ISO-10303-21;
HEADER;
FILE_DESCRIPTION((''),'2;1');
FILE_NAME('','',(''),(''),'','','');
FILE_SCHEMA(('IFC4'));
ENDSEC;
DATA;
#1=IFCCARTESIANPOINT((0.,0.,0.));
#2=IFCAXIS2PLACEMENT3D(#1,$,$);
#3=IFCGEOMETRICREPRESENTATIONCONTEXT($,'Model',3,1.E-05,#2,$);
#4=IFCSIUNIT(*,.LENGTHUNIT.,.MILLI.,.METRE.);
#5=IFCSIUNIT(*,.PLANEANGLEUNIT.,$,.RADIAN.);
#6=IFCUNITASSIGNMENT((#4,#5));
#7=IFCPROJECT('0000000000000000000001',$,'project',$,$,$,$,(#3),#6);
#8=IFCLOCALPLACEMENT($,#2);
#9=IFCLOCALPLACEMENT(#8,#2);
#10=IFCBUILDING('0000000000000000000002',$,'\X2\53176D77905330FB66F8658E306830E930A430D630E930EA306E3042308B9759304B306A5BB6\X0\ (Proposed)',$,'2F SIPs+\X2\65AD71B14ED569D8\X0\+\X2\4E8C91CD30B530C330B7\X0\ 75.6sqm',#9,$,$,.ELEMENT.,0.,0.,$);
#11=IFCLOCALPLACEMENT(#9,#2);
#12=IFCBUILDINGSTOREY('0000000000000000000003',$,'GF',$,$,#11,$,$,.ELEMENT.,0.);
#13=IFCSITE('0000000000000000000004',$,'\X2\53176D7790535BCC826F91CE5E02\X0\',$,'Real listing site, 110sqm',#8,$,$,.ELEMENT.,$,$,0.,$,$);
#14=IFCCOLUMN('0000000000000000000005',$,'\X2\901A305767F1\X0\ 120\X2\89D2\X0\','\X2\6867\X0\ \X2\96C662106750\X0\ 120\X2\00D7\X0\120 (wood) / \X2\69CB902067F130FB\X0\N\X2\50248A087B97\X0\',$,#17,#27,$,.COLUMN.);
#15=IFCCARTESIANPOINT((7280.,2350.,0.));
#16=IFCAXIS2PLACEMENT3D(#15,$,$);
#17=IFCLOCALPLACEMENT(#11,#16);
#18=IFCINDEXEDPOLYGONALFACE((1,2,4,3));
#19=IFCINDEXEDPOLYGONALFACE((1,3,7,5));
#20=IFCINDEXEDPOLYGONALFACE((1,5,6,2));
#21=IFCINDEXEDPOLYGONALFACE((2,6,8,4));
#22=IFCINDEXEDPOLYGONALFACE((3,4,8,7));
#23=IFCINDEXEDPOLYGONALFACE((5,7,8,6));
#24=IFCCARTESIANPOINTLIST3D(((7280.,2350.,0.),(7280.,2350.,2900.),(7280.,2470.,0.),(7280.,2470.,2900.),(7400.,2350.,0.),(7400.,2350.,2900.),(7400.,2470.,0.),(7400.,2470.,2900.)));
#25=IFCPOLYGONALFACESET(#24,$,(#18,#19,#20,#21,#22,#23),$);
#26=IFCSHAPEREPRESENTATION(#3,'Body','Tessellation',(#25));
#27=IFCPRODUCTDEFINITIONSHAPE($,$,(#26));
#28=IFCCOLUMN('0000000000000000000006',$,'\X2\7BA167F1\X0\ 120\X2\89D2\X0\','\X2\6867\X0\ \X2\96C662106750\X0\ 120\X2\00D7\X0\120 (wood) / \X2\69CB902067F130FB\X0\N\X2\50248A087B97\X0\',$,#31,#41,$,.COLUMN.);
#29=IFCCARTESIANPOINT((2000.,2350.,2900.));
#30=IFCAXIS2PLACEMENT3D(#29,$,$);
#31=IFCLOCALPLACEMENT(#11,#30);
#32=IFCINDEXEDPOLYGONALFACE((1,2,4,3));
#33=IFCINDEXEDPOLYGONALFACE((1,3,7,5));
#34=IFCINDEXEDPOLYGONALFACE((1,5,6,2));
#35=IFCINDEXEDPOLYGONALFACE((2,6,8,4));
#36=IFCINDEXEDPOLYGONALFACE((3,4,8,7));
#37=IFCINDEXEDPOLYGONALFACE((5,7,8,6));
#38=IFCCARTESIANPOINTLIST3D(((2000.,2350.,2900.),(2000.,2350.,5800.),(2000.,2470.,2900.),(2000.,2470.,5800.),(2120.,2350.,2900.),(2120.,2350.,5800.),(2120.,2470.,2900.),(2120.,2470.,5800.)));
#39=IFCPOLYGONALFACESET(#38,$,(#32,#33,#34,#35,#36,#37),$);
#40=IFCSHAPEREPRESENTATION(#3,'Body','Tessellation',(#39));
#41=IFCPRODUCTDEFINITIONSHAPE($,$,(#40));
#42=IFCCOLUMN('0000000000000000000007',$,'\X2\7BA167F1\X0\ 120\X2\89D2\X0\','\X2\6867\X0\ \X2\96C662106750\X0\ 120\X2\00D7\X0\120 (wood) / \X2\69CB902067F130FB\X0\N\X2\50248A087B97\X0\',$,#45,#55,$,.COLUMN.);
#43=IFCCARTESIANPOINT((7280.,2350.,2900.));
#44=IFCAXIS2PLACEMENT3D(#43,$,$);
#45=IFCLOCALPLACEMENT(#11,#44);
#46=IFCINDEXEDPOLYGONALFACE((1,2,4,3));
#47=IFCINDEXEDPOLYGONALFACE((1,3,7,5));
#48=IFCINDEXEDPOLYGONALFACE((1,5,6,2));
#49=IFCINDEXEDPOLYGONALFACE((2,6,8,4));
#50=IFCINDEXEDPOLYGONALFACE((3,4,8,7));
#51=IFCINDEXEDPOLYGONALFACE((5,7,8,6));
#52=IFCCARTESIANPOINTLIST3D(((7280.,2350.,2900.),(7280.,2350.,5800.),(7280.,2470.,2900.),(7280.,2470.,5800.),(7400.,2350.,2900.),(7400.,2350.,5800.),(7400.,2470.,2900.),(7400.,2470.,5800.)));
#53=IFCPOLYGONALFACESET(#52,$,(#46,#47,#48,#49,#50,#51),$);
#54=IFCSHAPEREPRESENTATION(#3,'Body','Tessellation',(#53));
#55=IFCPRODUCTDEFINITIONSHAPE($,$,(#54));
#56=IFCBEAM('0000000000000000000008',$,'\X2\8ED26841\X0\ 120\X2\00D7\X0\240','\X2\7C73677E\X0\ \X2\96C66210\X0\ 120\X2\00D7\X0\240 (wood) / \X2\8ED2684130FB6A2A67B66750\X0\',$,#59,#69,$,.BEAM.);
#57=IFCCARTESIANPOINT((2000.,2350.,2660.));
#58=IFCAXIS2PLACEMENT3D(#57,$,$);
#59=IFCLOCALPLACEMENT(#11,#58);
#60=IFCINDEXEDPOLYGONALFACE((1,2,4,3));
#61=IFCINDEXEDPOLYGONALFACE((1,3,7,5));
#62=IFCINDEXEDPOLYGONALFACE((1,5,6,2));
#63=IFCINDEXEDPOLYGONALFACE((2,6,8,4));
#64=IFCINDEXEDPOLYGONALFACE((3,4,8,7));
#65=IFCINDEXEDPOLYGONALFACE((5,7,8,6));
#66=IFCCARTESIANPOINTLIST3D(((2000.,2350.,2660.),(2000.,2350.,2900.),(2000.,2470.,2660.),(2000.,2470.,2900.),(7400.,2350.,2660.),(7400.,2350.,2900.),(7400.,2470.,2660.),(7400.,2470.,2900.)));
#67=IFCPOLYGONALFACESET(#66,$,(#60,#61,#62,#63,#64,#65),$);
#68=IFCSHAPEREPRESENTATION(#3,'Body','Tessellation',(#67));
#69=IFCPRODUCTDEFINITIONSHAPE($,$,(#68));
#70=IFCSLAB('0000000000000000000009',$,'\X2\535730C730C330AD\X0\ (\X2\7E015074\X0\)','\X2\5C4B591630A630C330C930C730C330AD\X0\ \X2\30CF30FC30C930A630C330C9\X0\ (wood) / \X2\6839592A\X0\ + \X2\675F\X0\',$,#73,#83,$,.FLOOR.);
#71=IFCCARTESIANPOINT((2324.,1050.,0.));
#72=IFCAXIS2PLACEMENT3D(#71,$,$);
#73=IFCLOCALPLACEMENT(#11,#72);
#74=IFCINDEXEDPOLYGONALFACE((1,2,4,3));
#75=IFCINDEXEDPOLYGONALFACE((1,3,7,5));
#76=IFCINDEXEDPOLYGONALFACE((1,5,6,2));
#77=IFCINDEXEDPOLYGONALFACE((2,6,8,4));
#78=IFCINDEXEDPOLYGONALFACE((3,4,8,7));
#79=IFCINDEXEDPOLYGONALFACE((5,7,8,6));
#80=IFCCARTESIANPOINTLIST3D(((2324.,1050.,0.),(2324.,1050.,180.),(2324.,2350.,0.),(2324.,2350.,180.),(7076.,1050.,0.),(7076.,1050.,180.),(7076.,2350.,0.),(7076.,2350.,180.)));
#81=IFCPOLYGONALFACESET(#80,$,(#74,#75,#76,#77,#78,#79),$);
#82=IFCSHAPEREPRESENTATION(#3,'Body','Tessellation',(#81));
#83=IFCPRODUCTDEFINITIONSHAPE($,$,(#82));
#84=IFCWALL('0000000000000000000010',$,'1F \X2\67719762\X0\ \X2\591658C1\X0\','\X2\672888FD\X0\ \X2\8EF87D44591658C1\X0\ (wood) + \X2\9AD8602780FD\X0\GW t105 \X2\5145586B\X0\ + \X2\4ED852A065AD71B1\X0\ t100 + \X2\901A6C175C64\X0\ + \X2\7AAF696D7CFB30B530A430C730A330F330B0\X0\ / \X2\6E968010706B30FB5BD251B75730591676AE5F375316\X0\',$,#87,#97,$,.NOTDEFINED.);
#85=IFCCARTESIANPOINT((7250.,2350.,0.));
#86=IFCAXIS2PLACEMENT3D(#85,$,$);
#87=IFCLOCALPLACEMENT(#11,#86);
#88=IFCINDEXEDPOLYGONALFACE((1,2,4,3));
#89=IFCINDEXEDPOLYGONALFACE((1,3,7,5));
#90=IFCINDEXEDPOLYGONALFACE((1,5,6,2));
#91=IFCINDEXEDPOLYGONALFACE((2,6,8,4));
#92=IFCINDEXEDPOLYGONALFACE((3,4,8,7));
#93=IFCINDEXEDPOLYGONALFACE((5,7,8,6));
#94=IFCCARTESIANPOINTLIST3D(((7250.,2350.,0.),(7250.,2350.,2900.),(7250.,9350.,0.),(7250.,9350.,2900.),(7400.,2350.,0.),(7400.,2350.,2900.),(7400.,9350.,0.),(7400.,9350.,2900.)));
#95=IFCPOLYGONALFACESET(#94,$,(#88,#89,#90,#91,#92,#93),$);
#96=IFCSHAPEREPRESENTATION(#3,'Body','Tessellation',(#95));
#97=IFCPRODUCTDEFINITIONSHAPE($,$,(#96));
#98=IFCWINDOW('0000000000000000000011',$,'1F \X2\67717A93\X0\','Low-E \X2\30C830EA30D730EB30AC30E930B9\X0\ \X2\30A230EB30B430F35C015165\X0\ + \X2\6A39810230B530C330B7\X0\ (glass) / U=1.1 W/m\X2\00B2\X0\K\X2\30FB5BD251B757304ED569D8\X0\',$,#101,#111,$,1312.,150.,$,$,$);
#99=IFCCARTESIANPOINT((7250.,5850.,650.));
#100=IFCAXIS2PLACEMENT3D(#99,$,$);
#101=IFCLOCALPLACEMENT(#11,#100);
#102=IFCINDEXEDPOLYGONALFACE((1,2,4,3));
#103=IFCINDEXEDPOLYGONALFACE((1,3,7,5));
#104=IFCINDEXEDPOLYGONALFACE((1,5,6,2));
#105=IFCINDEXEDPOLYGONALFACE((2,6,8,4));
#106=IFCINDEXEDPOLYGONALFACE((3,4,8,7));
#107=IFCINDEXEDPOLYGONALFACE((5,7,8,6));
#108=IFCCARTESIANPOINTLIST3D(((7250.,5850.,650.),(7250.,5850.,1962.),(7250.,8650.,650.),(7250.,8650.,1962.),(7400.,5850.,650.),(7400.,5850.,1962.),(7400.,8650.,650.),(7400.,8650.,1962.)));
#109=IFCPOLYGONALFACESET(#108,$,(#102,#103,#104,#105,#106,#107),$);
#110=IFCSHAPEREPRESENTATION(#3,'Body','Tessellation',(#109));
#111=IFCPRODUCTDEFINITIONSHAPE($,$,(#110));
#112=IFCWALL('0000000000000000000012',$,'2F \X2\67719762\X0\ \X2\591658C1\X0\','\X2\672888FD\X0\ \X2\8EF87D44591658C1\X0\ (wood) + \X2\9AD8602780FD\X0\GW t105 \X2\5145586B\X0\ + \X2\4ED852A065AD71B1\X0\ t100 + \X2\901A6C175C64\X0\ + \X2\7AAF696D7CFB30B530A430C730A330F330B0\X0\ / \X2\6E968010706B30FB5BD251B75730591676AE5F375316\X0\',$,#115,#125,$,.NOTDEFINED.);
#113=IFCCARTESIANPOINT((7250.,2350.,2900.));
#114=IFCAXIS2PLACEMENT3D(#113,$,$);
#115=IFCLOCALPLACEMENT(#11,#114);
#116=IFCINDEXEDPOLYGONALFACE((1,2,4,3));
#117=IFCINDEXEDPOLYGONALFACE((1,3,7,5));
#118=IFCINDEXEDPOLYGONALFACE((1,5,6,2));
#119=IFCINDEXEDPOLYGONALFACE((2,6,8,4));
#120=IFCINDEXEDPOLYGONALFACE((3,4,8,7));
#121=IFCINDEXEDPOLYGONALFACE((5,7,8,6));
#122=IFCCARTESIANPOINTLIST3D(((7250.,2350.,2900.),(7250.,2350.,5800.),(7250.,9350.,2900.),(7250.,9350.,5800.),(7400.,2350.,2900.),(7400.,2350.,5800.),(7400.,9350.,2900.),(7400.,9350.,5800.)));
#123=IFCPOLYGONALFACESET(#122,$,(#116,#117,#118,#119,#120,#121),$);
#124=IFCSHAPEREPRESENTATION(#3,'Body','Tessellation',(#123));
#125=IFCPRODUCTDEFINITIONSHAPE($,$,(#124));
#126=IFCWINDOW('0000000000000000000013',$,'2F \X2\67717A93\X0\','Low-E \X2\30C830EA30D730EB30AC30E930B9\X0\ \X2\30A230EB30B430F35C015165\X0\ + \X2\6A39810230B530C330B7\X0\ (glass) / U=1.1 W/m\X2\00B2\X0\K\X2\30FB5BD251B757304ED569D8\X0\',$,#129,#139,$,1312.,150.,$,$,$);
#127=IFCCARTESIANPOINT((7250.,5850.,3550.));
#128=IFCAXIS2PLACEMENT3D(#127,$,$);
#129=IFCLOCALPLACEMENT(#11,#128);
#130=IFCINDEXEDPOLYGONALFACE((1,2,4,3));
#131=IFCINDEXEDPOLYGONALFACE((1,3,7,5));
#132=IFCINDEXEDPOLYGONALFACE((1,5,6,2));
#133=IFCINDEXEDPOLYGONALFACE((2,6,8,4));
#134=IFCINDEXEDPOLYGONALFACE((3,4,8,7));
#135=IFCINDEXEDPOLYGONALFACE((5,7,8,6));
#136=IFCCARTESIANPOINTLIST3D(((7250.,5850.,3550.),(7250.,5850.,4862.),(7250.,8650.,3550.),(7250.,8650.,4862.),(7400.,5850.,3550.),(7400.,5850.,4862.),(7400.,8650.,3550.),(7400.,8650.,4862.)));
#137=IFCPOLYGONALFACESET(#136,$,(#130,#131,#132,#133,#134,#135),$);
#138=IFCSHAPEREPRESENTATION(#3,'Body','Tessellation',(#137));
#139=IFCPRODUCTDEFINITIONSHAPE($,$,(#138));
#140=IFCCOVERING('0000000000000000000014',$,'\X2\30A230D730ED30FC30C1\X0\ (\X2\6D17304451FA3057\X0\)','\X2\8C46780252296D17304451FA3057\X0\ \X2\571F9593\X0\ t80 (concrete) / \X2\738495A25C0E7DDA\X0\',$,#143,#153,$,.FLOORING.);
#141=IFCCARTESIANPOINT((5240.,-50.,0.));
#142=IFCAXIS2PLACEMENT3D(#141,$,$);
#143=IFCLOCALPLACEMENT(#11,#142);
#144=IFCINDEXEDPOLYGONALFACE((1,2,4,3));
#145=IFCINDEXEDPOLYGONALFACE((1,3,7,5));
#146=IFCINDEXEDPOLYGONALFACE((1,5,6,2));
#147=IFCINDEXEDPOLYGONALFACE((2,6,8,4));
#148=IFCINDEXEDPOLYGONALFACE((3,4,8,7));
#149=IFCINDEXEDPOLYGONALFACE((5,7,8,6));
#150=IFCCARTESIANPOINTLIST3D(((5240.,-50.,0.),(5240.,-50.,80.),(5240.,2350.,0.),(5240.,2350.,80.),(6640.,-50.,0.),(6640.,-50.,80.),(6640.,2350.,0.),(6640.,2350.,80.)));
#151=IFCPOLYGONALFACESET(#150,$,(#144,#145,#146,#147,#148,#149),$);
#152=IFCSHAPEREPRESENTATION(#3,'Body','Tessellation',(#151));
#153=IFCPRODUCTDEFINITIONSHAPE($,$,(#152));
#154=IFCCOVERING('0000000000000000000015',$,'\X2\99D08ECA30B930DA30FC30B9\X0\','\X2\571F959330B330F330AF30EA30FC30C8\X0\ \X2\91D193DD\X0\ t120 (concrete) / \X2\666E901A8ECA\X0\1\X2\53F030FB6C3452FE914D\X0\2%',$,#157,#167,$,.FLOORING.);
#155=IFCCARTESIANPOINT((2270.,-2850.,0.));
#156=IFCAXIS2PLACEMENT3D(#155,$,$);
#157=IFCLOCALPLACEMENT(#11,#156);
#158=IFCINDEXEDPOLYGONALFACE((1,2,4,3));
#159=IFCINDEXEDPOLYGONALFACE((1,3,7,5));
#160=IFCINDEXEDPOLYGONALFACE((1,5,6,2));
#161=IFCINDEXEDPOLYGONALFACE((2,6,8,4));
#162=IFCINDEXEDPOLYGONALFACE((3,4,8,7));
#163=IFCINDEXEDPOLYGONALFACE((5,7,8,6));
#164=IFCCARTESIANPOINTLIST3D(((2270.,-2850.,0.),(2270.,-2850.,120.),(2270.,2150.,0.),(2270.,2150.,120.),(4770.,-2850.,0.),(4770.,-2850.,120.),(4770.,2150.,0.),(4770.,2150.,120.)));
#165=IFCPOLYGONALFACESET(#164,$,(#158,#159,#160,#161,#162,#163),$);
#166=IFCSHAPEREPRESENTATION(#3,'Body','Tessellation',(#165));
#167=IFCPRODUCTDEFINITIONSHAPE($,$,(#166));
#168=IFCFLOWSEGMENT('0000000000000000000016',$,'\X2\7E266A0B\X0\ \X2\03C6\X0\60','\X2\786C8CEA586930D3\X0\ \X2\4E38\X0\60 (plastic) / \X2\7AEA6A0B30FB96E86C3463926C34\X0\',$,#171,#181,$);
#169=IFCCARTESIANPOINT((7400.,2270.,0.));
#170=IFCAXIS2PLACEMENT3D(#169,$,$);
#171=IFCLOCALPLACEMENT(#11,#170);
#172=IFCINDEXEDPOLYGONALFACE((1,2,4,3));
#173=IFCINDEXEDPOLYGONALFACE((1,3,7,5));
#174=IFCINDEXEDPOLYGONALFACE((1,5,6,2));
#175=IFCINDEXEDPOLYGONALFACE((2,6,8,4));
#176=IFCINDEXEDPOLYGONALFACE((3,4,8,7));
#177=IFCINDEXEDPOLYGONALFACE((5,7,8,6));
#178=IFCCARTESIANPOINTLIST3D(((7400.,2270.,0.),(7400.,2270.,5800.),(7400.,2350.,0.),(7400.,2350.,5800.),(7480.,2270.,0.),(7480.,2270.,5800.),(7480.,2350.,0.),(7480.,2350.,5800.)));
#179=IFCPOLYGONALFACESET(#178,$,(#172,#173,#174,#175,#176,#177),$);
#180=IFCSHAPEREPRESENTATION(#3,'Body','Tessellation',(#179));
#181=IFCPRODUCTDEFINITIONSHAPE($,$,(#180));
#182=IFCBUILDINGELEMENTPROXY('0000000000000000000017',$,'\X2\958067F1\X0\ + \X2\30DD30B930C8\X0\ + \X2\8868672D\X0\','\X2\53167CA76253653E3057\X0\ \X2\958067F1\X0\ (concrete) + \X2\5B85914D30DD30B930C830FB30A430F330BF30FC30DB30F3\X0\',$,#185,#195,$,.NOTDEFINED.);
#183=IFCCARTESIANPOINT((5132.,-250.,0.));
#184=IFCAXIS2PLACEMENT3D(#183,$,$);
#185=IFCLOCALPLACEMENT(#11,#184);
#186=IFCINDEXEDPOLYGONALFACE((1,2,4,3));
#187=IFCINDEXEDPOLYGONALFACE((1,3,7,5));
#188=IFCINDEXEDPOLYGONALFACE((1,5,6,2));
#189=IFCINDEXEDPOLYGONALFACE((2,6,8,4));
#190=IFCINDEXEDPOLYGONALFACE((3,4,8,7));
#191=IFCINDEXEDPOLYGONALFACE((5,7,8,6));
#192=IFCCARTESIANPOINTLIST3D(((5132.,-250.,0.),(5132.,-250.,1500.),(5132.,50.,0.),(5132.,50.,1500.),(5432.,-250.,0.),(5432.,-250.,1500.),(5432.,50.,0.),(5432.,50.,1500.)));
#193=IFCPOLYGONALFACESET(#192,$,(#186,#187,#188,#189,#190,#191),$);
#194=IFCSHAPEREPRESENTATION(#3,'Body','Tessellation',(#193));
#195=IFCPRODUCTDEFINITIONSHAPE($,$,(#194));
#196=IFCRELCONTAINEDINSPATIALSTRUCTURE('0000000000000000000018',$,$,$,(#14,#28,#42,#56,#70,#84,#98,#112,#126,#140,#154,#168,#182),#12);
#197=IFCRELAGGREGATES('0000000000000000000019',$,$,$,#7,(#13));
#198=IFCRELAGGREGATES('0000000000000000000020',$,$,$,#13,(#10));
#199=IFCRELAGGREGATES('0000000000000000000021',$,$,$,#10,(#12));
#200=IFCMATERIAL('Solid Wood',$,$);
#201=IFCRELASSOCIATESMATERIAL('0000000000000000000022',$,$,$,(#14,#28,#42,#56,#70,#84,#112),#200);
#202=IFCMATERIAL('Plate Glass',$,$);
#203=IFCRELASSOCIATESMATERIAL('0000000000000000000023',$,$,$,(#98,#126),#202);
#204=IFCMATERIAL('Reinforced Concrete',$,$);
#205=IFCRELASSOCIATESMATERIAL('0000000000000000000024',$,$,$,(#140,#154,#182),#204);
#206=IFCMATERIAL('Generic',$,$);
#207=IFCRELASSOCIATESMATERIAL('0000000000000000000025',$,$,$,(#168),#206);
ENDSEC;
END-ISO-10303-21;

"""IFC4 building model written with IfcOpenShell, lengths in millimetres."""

from ifc_helpers import new_model, si_unit, frame, frame_2d, origin, place, context, project, spatial, rectangle, extrude, material, element, fill, save


model = new_model("IFC4")

# Units and contexts
model_context = context("Model", 3, precision=1e-05, world=origin())
ifc_project = project(units=[si_unit("LENGTHUNIT", "METRE", prefix="MILLI"), si_unit("PLANEANGLEUNIT", "RADIAN")], contexts=[model_context])

# Site, building, storey
site_placement = place(None, origin())
site = spatial("IfcSite", under=ifc_project, at=site_placement, Name="北海道富良野市", ObjectType="Real listing site, 110sqm", CompositionType="ELEMENT", RefElevation=0.0)
building_placement = place(site_placement, origin())
building = spatial("IfcBuilding", under=site, at=building_placement, Name="北海道・書斎とライブラリのある静かな家 (Proposed)", ObjectType="2F SIPs+断熱仕様+二重サッシ 75.6sqm", CompositionType="ELEMENT", ElevationOfRefHeight=0.0, ElevationOfTerrain=0.0)
storey_placement = place(building_placement, origin())
storey = spatial("IfcBuildingStorey", under=building, at=storey_placement, Name="GF", CompositionType="ELEMENT", Elevation=0.0)

# Columns
ifc_material_1 = material(Name="Solid Wood")
column_1_placement = place(storey_placement, frame((7280.0, 2350.0, 0.0)))
element("IfcColumn", 1, at=column_1_placement, inside=storey, material=ifc_material_1, Name="通し柱 120角", Description="桧 集成材 120×120 (wood) / 構造柱・N値計算", PredefinedType="COLUMN", context=model_context, shape_type="SweptSolid", body=[
    extrude(rectangle(XDim=120.0, YDim=120.0, at=frame_2d((60.0, 60.0))), frame((7280.0, 2350.0, 0.0)), (0.0, 0.0, 1.0), 2900.0),
])
column_2_placement = place(storey_placement, frame((2000.0, 2350.0, 2900.0)))
element("IfcColumn", 2, at=column_2_placement, inside=storey, material=ifc_material_1, Name="管柱 120角", Description="桧 集成材 120×120 (wood) / 構造柱・N値計算", PredefinedType="COLUMN", context=model_context, shape_type="SweptSolid", body=[
    extrude(rectangle(XDim=120.0, YDim=120.0, at=frame_2d((60.0, 60.0))), frame((2000.0, 2350.0, 2900.0)), (0.0, 0.0, 1.0), 2900.0),
])
column_3_placement = place(storey_placement, frame((7280.0, 2350.0, 2900.0)))
element("IfcColumn", 3, at=column_3_placement, inside=storey, material=ifc_material_1, Name="管柱 120角", Description="桧 集成材 120×120 (wood) / 構造柱・N値計算", PredefinedType="COLUMN", context=model_context, shape_type="SweptSolid", body=[
    extrude(rectangle(XDim=120.0, YDim=120.0, at=frame_2d((60.0, 60.0))), frame((7280.0, 2350.0, 2900.0)), (0.0, 0.0, 1.0), 2900.0),
])

# Beam
beam_1_placement = place(storey_placement, frame((2000.0, 2350.0, 2660.0)))
element("IfcBeam", 4, at=beam_1_placement, inside=storey, material=ifc_material_1, Name="軒桁 120×240", Description="米松 集成 120×240 (wood) / 軒桁・横架材", PredefinedType="BEAM", context=model_context, shape_type="SweptSolid", body=[
    extrude(rectangle(XDim=5400.0, YDim=120.0, at=frame_2d((2700.0, 60.0))), frame((2000.0, 2350.0, 2660.0)), (0.0, 0.0, 1.0), 240.0),
])

# Slab
slab_placement = place(storey_placement, frame((2324.0, 1050.0, 0.0)))
element("IfcSlab", 5, at=slab_placement, inside=storey, material=ifc_material_1, Name="南デッキ (縁側)", Description="屋外ウッドデッキ ハードウッド (wood) / 根太 + 束", PredefinedType="FLOOR", context=model_context, shape_type="SweptSolid", body=[
    extrude(rectangle(XDim=4752.0, YDim=1300.0, at=frame_2d((2376.0, 650.0))), frame((2324.0, 1050.0, 0.0)), (0.0, 0.0, 1.0), 180.0),
])

# Walls, openings, windows
wall_1_placement = place(storey_placement, frame((7250.0, 2350.0, 0.0)))
wall_1 = element("IfcWall", 6, at=wall_1_placement, inside=storey, material=ifc_material_1, Name="1F 東面 外壁", Description="木製 軸組外壁 (wood) + 高性能GW t105 充填 + 付加断熱 t100 + 通気層 + 窯業系サイディング / 準耐火・寒冷地外皮強化", PredefinedType="NOTDEFINED", context=model_context, shape_type="SweptSolid", body=[
    extrude(rectangle(XDim=150.0, YDim=7000.0, at=frame_2d((75.0, 3500.0))), frame((7250.0, 2350.0, 0.0)), (0.0, 0.0, 1.0), 2900.0),
])
opening_1_placement = place(storey_placement, frame((7250.0, 5850.0, 650.0)))
opening_1 = element("IfcOpeningElement", 7, at=opening_1_placement, cuts=wall_1, PredefinedType="NOTDEFINED", context=model_context, shape_type="SweptSolid", body=[
    extrude(rectangle(XDim=150.0, YDim=2800.0, at=frame_2d((75.0, 1400.0))), frame((7250.0, 5850.0, 650.0)), (0.0, 0.0, 1.0), 1312.0),
])
ifc_material_2 = material(Name="Plate Glass")
window_1_placement = place(storey_placement, frame((7250.0, 5850.0, 650.0)))
window_1 = element("IfcWindow", 8, at=window_1_placement, inside=storey, material=ifc_material_2, Name="1F 東窓", Description="Low-E トリプルガラス アルゴン封入 + 樹脂サッシ (glass) / U=1.1 W/m²K・寒冷地仕様", OverallHeight=1312.0, OverallWidth=150.0, context=model_context, shape_type="SweptSolid", body=[
    extrude(rectangle(XDim=150.0, YDim=2800.0, at=frame_2d((75.0, 1400.0))), frame((7250.0, 5850.0, 650.0)), (0.0, 0.0, 1.0), 1312.0),
])
fill(opening_1, window_1)
wall_2_placement = place(storey_placement, frame((7250.0, 2350.0, 2900.0)))
wall_2 = element("IfcWall", 9, at=wall_2_placement, inside=storey, material=ifc_material_1, Name="2F 東面 外壁", Description="木製 軸組外壁 (wood) + 高性能GW t105 充填 + 付加断熱 t100 + 通気層 + 窯業系サイディング / 準耐火・寒冷地外皮強化", PredefinedType="NOTDEFINED", context=model_context, shape_type="SweptSolid", body=[
    extrude(rectangle(XDim=150.0, YDim=7000.0, at=frame_2d((75.0, 3500.0))), frame((7250.0, 2350.0, 2900.0)), (0.0, 0.0, 1.0), 2900.0),
])
opening_2_placement = place(storey_placement, frame((7250.0, 5850.0, 3550.0)))
opening_2 = element("IfcOpeningElement", 10, at=opening_2_placement, cuts=wall_2, PredefinedType="NOTDEFINED", context=model_context, shape_type="SweptSolid", body=[
    extrude(rectangle(XDim=150.0, YDim=2800.0, at=frame_2d((75.0, 1400.0))), frame((7250.0, 5850.0, 3550.0)), (0.0, 0.0, 1.0), 1312.0),
])
window_2_placement = place(storey_placement, frame((7250.0, 5850.0, 3550.0)))
window_2 = element("IfcWindow", 11, at=window_2_placement, inside=storey, material=ifc_material_2, Name="2F 東窓", Description="Low-E トリプルガラス アルゴン封入 + 樹脂サッシ (glass) / U=1.1 W/m²K・寒冷地仕様", OverallHeight=1312.0, OverallWidth=150.0, context=model_context, shape_type="SweptSolid", body=[
    extrude(rectangle(XDim=150.0, YDim=2800.0, at=frame_2d((75.0, 1400.0))), frame((7250.0, 5850.0, 3550.0)), (0.0, 0.0, 1.0), 1312.0),
])
fill(opening_2, window_2)

# Coverings
ifc_material_3 = material(Name="Reinforced Concrete")
covering_1_placement = place(storey_placement, frame((5240.0, -50.0, 0.0)))
element("IfcCovering", 12, at=covering_1_placement, inside=storey, material=ifc_material_3, Name="アプローチ (洗い出し)", Description="豆砂利洗い出し 土間 t80 (concrete) / 玄関導線", PredefinedType="FLOORING", context=model_context, shape_type="SweptSolid", body=[
    extrude(rectangle(XDim=1400.0, YDim=2400.0, at=frame_2d((700.0, 1200.0))), frame((5240.0, -50.0, 0.0)), (0.0, 0.0, 1.0), 80.0),
])
covering_2_placement = place(storey_placement, frame((2270.0, -2850.0, 0.0)))
element("IfcCovering", 13, at=covering_2_placement, inside=storey, material=ifc_material_3, Name="駐車スペース", Description="土間コンクリート 金鏝 t120 (concrete) / 普通車1台・水勾配2%", PredefinedType="FLOORING", context=model_context, shape_type="SweptSolid", body=[
    extrude(rectangle(XDim=2500.0, YDim=5000.0, at=frame_2d((1250.0, 2500.0))), frame((2270.0, -2850.0, 0.0)), (0.0, 0.0, 1.0), 120.0),
])

# Flow segment
ifc_material_4 = material(Name="Generic")
flow_segment_placement = place(storey_placement, frame((7400.0, 2270.0, 0.0)))
element("IfcFlowSegment", 14, at=flow_segment_placement, inside=storey, material=ifc_material_4, Name="縦樋 φ60", Description="硬質塩ビ 丸60 (plastic) / 竪樋・雨水排水", context=model_context, shape_type="SweptSolid", body=[
    extrude(rectangle(XDim=80.0, YDim=80.0, at=frame_2d((40.0, 40.0))), frame((7400.0, 2270.0, 0.0)), (0.0, 0.0, 1.0), 5800.0),
])

# Building element proxy
proxy_placement = place(storey_placement, frame((5132.0, -250.0, 0.0)))
element("IfcBuildingElementProxy", 15, at=proxy_placement, inside=storey, material=ifc_material_3, Name="門柱 + ポスト + 表札", Description="化粧打放し 門柱 (concrete) + 宅配ポスト・インターホン", PredefinedType="NOTDEFINED", context=model_context, shape_type="SweptSolid", body=[
    extrude(rectangle(XDim=300.0, YDim=300.0, at=frame_2d((150.0, 150.0))), frame((5132.0, -250.0, 0.0)), (0.0, 0.0, 1.0), 1500.0),
])

save(model, "model.ifc")
